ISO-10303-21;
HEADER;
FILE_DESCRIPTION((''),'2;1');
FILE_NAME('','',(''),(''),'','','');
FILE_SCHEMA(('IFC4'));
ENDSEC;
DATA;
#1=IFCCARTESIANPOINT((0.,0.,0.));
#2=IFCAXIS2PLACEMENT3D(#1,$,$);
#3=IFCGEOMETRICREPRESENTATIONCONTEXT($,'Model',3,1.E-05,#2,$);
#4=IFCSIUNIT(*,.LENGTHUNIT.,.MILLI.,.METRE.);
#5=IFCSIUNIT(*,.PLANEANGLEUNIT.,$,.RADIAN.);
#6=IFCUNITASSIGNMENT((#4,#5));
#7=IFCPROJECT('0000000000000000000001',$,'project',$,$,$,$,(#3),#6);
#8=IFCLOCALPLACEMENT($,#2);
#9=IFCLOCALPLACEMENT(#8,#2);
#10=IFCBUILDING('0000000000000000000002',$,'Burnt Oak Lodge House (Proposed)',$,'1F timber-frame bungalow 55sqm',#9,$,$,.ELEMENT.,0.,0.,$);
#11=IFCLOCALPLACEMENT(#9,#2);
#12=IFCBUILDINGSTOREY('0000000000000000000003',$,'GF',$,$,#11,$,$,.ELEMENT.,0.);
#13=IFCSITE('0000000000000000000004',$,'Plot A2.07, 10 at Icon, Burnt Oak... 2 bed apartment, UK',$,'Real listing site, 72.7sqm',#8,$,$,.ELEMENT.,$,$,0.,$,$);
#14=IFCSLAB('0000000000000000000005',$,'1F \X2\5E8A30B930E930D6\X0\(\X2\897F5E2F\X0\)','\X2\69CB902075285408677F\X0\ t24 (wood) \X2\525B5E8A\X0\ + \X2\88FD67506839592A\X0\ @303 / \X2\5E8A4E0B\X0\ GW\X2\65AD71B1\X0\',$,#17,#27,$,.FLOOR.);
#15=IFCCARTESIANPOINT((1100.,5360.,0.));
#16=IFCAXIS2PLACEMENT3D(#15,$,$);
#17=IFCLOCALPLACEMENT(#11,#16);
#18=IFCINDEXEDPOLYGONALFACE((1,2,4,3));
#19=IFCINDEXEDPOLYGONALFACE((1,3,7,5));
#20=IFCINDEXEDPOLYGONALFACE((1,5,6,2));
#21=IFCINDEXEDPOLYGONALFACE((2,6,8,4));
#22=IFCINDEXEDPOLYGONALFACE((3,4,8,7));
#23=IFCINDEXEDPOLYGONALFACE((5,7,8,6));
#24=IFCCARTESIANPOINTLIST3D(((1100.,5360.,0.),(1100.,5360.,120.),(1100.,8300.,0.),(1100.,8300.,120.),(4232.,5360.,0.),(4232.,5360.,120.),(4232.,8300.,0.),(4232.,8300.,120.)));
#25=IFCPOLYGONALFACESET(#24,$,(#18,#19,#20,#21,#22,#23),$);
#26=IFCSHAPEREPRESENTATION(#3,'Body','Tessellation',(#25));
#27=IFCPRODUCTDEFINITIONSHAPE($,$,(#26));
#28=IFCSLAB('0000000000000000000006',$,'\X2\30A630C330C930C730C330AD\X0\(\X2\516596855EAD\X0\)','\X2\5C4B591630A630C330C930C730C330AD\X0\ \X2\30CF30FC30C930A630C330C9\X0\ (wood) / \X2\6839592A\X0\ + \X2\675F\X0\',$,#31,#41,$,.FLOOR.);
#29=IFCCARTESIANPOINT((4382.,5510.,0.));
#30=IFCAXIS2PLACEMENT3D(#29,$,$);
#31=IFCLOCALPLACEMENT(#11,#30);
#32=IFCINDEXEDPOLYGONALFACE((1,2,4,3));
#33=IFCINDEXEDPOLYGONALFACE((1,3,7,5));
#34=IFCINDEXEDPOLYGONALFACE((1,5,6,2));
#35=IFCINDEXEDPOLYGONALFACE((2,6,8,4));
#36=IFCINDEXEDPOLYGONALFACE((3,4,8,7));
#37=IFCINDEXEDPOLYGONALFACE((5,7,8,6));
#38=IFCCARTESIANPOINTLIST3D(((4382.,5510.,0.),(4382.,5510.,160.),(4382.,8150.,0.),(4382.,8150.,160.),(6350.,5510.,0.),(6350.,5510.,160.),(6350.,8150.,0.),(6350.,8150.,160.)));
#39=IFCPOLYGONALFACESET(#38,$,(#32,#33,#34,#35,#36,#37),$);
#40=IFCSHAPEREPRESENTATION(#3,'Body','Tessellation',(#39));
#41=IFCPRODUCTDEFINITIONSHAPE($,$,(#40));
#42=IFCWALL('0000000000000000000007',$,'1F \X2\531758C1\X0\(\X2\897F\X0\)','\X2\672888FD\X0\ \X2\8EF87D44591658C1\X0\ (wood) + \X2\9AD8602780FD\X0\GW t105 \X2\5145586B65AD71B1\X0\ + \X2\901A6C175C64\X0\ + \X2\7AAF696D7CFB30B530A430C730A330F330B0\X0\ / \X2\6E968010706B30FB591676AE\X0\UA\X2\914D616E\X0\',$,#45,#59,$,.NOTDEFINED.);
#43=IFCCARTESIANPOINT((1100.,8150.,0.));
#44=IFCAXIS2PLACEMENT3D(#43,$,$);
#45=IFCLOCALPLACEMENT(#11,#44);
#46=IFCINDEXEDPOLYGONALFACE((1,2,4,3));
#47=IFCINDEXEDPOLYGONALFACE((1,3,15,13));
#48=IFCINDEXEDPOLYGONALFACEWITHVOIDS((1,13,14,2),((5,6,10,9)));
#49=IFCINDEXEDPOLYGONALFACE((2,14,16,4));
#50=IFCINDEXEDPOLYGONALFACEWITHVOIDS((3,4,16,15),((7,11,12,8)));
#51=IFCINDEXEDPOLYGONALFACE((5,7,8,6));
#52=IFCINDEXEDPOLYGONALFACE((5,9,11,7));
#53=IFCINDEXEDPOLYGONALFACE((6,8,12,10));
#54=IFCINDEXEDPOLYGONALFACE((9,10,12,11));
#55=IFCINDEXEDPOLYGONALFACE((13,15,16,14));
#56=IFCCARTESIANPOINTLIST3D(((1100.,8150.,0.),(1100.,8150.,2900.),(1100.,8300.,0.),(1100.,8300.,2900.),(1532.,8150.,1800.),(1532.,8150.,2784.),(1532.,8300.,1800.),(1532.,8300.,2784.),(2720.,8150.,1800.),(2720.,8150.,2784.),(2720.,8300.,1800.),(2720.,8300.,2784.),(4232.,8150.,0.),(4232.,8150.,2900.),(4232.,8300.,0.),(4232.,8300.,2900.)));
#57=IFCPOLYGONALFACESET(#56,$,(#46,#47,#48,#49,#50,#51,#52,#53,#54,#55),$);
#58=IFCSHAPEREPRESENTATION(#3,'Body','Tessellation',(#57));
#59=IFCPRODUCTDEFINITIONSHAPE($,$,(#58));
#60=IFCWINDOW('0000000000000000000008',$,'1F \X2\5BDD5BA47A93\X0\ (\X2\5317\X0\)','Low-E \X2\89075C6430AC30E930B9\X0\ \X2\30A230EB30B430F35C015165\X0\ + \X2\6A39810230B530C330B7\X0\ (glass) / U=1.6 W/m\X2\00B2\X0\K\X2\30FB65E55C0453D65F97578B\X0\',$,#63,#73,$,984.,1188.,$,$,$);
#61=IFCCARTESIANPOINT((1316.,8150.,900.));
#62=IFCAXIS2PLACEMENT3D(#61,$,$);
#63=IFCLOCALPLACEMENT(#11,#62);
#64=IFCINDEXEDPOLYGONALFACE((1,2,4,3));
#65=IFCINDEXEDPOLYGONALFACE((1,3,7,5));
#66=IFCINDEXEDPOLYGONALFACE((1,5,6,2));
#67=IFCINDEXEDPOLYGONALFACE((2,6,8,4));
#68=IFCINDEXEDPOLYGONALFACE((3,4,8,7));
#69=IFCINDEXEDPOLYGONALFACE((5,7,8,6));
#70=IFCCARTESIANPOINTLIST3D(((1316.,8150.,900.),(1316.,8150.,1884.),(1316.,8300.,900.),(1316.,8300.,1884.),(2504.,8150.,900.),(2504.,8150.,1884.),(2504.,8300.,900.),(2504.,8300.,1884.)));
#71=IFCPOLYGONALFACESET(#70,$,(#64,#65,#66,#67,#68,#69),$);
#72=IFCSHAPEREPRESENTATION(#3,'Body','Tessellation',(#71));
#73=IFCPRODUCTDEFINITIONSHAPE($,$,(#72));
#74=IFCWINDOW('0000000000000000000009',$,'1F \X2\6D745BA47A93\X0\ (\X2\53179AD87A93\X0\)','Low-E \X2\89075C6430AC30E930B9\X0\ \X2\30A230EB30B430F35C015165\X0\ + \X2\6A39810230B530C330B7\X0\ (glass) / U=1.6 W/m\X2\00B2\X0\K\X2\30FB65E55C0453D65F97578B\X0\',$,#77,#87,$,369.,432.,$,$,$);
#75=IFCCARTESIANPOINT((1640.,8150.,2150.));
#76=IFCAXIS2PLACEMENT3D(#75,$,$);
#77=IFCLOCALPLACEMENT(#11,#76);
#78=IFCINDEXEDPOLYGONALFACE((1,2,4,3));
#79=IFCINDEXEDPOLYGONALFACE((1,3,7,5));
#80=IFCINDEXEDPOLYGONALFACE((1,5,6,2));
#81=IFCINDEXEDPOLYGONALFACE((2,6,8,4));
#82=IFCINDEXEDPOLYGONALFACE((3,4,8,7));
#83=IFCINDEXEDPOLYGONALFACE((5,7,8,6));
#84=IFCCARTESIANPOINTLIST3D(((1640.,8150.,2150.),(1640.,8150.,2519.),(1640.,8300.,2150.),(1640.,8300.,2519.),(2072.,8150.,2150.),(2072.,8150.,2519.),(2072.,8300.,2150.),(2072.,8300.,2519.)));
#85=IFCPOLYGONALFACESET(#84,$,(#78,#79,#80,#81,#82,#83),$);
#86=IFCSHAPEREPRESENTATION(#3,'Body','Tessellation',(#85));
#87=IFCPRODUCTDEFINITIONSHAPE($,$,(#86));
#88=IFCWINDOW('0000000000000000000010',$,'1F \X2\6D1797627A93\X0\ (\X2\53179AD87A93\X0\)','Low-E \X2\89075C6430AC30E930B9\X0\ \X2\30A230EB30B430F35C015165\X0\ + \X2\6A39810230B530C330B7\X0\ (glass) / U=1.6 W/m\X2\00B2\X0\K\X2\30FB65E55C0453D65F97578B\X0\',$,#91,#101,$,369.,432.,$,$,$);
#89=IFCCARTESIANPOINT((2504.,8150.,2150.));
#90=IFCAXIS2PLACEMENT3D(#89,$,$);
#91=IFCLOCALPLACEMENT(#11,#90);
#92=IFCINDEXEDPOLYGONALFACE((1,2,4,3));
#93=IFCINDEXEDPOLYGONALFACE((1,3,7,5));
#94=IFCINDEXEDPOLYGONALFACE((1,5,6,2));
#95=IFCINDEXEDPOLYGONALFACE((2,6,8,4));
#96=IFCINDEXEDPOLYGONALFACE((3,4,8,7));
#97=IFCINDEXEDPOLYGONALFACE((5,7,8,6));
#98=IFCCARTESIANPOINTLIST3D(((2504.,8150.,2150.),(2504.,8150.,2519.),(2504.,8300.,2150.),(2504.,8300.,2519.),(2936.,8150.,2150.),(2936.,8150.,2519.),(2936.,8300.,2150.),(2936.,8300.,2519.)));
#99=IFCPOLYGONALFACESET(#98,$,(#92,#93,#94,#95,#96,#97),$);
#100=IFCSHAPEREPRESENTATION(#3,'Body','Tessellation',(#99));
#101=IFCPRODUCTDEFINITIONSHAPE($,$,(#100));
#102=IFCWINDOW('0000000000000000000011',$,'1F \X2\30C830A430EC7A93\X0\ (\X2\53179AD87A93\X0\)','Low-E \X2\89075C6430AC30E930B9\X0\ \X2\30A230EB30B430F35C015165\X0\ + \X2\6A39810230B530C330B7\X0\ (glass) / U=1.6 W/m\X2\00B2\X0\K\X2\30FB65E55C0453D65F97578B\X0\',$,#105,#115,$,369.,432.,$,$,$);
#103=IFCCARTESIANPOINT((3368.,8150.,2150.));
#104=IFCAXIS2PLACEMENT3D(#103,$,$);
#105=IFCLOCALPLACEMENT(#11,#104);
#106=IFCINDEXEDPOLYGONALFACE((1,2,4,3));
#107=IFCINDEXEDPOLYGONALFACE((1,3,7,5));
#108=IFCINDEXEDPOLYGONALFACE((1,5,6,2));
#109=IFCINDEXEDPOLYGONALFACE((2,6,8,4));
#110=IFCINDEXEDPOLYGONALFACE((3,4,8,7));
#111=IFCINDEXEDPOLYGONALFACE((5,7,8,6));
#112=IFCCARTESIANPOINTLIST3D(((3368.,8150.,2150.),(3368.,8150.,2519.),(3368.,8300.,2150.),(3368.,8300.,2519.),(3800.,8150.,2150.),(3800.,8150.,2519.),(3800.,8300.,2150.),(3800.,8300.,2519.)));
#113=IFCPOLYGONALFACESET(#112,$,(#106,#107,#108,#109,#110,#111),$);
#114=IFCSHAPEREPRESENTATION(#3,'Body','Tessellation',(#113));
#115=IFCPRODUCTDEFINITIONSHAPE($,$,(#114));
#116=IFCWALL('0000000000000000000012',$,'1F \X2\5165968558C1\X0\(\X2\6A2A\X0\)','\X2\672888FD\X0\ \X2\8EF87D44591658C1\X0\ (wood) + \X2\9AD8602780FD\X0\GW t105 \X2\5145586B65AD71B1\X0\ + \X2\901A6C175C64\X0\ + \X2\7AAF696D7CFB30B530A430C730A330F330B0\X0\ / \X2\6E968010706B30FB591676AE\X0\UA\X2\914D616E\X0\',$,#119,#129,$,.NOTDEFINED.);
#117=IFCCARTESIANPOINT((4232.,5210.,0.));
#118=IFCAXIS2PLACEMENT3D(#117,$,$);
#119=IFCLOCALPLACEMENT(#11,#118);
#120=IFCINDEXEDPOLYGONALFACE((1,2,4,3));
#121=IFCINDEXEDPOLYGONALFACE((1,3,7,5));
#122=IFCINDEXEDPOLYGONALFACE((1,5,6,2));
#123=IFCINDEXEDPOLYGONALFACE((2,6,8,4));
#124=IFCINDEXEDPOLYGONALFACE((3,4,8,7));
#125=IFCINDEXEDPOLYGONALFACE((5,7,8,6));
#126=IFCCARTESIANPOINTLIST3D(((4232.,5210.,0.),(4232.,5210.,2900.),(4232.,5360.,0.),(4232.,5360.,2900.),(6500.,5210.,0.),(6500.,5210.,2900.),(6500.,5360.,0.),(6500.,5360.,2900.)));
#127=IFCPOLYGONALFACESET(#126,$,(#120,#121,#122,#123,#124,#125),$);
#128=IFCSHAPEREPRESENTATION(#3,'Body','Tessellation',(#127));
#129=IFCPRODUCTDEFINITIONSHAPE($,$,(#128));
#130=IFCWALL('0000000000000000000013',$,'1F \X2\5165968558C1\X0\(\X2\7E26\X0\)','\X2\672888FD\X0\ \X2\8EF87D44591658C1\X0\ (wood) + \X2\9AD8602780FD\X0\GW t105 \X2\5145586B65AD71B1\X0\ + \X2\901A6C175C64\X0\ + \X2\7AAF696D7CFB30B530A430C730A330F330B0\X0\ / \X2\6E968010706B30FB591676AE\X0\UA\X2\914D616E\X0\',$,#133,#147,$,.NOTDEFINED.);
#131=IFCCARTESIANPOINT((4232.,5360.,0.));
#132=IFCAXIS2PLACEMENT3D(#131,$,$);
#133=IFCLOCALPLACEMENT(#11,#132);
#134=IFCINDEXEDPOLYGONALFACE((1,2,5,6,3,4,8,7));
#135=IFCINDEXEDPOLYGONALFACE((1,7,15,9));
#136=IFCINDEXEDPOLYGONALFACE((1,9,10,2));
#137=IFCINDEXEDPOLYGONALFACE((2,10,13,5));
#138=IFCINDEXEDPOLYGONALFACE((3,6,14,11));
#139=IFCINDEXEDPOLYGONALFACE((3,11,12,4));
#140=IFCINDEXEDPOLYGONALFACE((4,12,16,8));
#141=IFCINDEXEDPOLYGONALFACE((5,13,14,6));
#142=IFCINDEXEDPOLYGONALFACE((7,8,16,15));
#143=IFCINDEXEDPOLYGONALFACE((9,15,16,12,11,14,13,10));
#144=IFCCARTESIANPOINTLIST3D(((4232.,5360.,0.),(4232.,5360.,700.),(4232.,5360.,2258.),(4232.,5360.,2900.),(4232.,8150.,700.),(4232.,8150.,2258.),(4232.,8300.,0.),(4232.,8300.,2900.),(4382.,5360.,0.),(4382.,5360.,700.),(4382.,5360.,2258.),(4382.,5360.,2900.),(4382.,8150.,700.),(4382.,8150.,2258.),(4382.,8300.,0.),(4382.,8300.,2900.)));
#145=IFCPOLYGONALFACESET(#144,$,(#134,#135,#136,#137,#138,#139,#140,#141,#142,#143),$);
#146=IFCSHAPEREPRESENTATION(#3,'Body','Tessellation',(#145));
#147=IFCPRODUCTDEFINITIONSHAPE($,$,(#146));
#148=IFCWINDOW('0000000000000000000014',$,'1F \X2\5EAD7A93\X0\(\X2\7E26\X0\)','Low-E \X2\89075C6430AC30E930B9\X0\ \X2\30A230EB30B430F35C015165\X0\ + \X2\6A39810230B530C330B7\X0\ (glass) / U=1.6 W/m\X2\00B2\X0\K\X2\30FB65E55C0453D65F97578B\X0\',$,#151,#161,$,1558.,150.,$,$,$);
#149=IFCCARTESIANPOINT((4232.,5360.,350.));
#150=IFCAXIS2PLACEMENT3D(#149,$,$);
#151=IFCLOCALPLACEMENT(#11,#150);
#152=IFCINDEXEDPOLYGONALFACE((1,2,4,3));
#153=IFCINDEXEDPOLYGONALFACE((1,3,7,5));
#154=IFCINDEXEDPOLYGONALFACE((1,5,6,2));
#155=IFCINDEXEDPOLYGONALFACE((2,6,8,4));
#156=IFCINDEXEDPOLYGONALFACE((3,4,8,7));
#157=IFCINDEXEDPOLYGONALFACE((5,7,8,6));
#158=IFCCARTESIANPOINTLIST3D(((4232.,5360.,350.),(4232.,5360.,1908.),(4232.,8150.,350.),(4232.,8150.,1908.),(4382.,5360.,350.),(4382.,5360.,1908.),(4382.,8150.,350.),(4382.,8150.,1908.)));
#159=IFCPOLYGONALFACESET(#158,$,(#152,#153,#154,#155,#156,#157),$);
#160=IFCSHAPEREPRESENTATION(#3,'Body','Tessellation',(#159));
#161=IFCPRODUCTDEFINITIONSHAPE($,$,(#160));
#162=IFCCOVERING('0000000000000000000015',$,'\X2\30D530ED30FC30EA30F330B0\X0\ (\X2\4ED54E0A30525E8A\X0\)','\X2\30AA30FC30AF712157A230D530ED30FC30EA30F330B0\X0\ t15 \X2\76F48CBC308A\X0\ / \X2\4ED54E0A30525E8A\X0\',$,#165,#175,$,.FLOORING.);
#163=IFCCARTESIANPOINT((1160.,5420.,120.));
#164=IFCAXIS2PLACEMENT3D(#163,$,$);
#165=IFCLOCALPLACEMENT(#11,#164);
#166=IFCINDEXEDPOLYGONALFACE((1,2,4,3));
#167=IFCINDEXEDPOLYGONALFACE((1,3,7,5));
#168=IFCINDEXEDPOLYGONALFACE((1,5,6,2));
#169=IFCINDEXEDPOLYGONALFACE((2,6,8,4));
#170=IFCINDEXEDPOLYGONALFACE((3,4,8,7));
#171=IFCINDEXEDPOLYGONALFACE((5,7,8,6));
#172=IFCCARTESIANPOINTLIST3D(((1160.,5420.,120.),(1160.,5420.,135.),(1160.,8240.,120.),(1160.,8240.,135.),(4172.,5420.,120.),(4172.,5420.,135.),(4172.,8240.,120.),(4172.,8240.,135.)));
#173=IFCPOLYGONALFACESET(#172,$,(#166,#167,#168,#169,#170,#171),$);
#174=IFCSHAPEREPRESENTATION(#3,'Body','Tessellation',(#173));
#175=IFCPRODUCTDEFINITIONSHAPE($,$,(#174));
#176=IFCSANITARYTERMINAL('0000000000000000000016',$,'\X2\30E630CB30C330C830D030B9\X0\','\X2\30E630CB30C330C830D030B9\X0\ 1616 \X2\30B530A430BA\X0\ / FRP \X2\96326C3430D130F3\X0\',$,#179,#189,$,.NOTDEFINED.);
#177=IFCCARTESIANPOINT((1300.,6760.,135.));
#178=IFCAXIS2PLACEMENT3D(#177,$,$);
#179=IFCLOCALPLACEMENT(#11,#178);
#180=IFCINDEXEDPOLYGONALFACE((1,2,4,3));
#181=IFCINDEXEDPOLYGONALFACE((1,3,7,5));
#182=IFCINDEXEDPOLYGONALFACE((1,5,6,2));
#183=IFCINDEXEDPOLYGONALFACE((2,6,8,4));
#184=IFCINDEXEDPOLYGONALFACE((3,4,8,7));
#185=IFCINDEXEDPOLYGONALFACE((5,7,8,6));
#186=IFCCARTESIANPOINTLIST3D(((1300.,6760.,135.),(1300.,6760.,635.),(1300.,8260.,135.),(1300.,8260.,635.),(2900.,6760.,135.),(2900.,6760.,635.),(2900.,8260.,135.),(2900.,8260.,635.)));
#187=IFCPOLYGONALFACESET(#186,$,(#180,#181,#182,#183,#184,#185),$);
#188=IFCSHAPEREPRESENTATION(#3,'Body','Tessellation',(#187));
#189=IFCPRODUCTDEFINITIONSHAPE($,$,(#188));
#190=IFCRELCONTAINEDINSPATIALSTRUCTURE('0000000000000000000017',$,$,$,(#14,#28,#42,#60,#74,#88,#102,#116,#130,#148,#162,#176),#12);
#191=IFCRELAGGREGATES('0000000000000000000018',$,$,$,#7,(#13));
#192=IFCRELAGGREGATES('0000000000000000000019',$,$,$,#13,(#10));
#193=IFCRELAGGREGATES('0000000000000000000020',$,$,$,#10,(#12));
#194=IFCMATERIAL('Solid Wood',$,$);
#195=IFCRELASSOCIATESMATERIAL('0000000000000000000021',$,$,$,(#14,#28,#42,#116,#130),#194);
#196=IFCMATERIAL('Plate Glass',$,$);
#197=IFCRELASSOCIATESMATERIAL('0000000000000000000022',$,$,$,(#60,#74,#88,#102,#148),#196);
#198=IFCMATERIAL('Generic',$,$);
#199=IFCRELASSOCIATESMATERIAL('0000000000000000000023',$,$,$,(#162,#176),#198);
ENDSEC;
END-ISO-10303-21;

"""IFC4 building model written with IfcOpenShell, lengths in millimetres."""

from ifc_helpers import new_model, si_unit, frame, frame_2d, origin, place, context, project, spatial, rectangle, extrude, material, element, fill, save


model = new_model("IFC4")

# Units and contexts
model_context = context("Model", 3, precision=1e-05, world=origin())
ifc_project = project(units=[si_unit("LENGTHUNIT", "METRE", prefix="MILLI"), si_unit("PLANEANGLEUNIT", "RADIAN")], contexts=[model_context])

# Site, building, storey
site_placement = place(None, origin())
site = spatial("IfcSite", under=ifc_project, at=site_placement, Name="Plot A2.07, 10 at Icon, Burnt Oak... 2 bed apartment, UK", ObjectType="Real listing site, 72.7sqm", CompositionType="ELEMENT", RefElevation=0.0)
building_placement = place(site_placement, origin())
building = spatial("IfcBuilding", under=site, at=building_placement, Name="Burnt Oak Lodge House (Proposed)", ObjectType="1F timber-frame bungalow 55sqm", CompositionType="ELEMENT", ElevationOfRefHeight=0.0, ElevationOfTerrain=0.0)
storey_placement = place(building_placement, origin())
storey = spatial("IfcBuildingStorey", under=building, at=storey_placement, Name="GF", CompositionType="ELEMENT", Elevation=0.0)

# Slabs
ifc_material_1 = material(Name="Solid Wood")
slab_1_placement = place(storey_placement, frame((1100.0, 5360.0, 0.0)))
element("IfcSlab", 1, at=slab_1_placement, inside=storey, material=ifc_material_1, Name="1F 床スラブ(西帯)", Description="構造用合板 t24 (wood) 剛床 + 製材根太 @303 / 床下 GW断熱", PredefinedType="FLOOR", context=model_context, shape_type="SweptSolid", body=[
    extrude(rectangle(XDim=3132.0, YDim=2940.0, at=frame_2d((1566.0, 1470.0))), frame((1100.0, 5360.0, 0.0)), (0.0, 0.0, 1.0), 120.0),
])
slab_2_placement = place(storey_placement, frame((4382.0, 5510.0, 0.0)))
element("IfcSlab", 2, at=slab_2_placement, inside=storey, material=ifc_material_1, Name="ウッドデッキ(入隅庭)", Description="屋外ウッドデッキ ハードウッド (wood) / 根太 + 束", PredefinedType="FLOOR", context=model_context, shape_type="SweptSolid", body=[
    extrude(rectangle(XDim=1968.0, YDim=2640.0, at=frame_2d((984.0, 1320.0))), frame((4382.0, 5510.0, 0.0)), (0.0, 0.0, 1.0), 160.0),
])

# Wall, openings, windows
wall_1_placement = place(storey_placement, frame((1100.0, 8150.0, 0.0)))
wall_1 = element("IfcWall", 3, at=wall_1_placement, inside=storey, material=ifc_material_1, Name="1F 北壁(西)", Description="木製 軸組外壁 (wood) + 高性能GW t105 充填断熱 + 通気層 + 窯業系サイディング / 準耐火・外皮UA配慮", PredefinedType="NOTDEFINED", context=model_context, shape_type="SweptSolid", body=[
    extrude(rectangle(XDim=3132.0, YDim=150.0, at=frame_2d((1566.0, 75.0))), frame((1100.0, 8150.0, 0.0)), (0.0, 0.0, 1.0), 2900.0),
])
opening_1_placement = place(storey_placement, frame((1316.0, 8150.0, 900.0)))
opening_1 = element("IfcOpeningElement", 4, at=opening_1_placement, cuts=wall_1, PredefinedType="NOTDEFINED", context=model_context, shape_type="SweptSolid", body=[
    extrude(rectangle(XDim=1188.0, YDim=150.0, at=frame_2d((594.0, 75.0))), frame((1316.0, 8150.0, 900.0)), (0.0, 0.0, 1.0), 984.0),
])
opening_2_placement = place(storey_placement, frame((1640.0, 8150.0, 2150.0)))
opening_2 = element("IfcOpeningElement", 5, at=opening_2_placement, cuts=wall_1, PredefinedType="NOTDEFINED", context=model_context, shape_type="SweptSolid", body=[
    extrude(rectangle(XDim=432.0, YDim=150.0, at=frame_2d((216.0, 75.0))), frame((1640.0, 8150.0, 2150.0)), (0.0, 0.0, 1.0), 369.0),
])
opening_3_placement = place(storey_placement, frame((2504.0, 8150.0, 2150.0)))
opening_3 = element("IfcOpeningElement", 6, at=opening_3_placement, cuts=wall_1, PredefinedType="NOTDEFINED", context=model_context, shape_type="SweptSolid", body=[
    extrude(rectangle(XDim=432.0, YDim=150.0, at=frame_2d((216.0, 75.0))), frame((2504.0, 8150.0, 2150.0)), (0.0, 0.0, 1.0), 369.0),
])
opening_4_placement = place(storey_placement, frame((3368.0, 8150.0, 2150.0)))
opening_4 = element("IfcOpeningElement", 7, at=opening_4_placement, cuts=wall_1, PredefinedType="NOTDEFINED", context=model_context, shape_type="SweptSolid", body=[
    extrude(rectangle(XDim=432.0, YDim=150.0, at=frame_2d((216.0, 75.0))), frame((3368.0, 8150.0, 2150.0)), (0.0, 0.0, 1.0), 369.0),
])
ifc_material_2 = material(Name="Plate Glass")
window_1_placement = place(storey_placement, frame((1316.0, 8150.0, 900.0)))
window_1 = element("IfcWindow", 8, at=window_1_placement, inside=storey, material=ifc_material_2, Name="1F 寝室窓 (北)", Description="Low-E 複層ガラス アルゴン封入 + 樹脂サッシ (glass) / U=1.6 W/m²K・日射取得型", OverallHeight=984.0, OverallWidth=1188.0, context=model_context, shape_type="SweptSolid", body=[
    extrude(rectangle(XDim=1188.0, YDim=150.0, at=frame_2d((594.0, 75.0))), frame((1316.0, 8150.0, 900.0)), (0.0, 0.0, 1.0), 984.0),
])
fill(opening_1, window_1)
window_2_placement = place(storey_placement, frame((1640.0, 8150.0, 2150.0)))
window_2 = element("IfcWindow", 9, at=window_2_placement, inside=storey, material=ifc_material_2, Name="1F 浴室窓 (北高窓)", Description="Low-E 複層ガラス アルゴン封入 + 樹脂サッシ (glass) / U=1.6 W/m²K・日射取得型", OverallHeight=369.0, OverallWidth=432.0, context=model_context, shape_type="SweptSolid", body=[
    extrude(rectangle(XDim=432.0, YDim=150.0, at=frame_2d((216.0, 75.0))), frame((1640.0, 8150.0, 2150.0)), (0.0, 0.0, 1.0), 369.0),
])
fill(opening_2, window_2)
window_3_placement = place(storey_placement, frame((2504.0, 8150.0, 2150.0)))
window_3 = element("IfcWindow", 10, at=window_3_placement, inside=storey, material=ifc_material_2, Name="1F 洗面窓 (北高窓)", Description="Low-E 複層ガラス アルゴン封入 + 樹脂サッシ (glass) / U=1.6 W/m²K・日射取得型", OverallHeight=369.0, OverallWidth=432.0, context=model_context, shape_type="SweptSolid", body=[
    extrude(rectangle(XDim=432.0, YDim=150.0, at=frame_2d((216.0, 75.0))), frame((2504.0, 8150.0, 2150.0)), (0.0, 0.0, 1.0), 369.0),
])
fill(opening_3, window_3)
window_4_placement = place(storey_placement, frame((3368.0, 8150.0, 2150.0)))
window_4 = element("IfcWindow", 11, at=window_4_placement, inside=storey, material=ifc_material_2, Name="1F トイレ窓 (北高窓)", Description="Low-E 複層ガラス アルゴン封入 + 樹脂サッシ (glass) / U=1.6 W/m²K・日射取得型", OverallHeight=369.0, OverallWidth=432.0, context=model_context, shape_type="SweptSolid", body=[
    extrude(rectangle(XDim=432.0, YDim=150.0, at=frame_2d((216.0, 75.0))), frame((3368.0, 8150.0, 2150.0)), (0.0, 0.0, 1.0), 369.0),
])
fill(opening_4, window_4)

# Wall
wall_2_placement = place(storey_placement, frame((4232.0, 5210.0, 0.0)))
element("IfcWall", 12, at=wall_2_placement, inside=storey, material=ifc_material_1, Name="1F 入隅壁(横)", Description="木製 軸組外壁 (wood) + 高性能GW t105 充填断熱 + 通気層 + 窯業系サイディング / 準耐火・外皮UA配慮", PredefinedType="NOTDEFINED", context=model_context, shape_type="SweptSolid", body=[
    extrude(rectangle(XDim=2268.0, YDim=150.0, at=frame_2d((1134.0, 75.0))), frame((4232.0, 5210.0, 0.0)), (0.0, 0.0, 1.0), 2900.0),
])

# Wall, opening, window
wall_3_placement = place(storey_placement, frame((4232.0, 5360.0, 0.0)))
wall_3 = element("IfcWall", 13, at=wall_3_placement, inside=storey, material=ifc_material_1, Name="1F 入隅壁(縦)", Description="木製 軸組外壁 (wood) + 高性能GW t105 充填断熱 + 通気層 + 窯業系サイディング / 準耐火・外皮UA配慮", PredefinedType="NOTDEFINED", context=model_context, shape_type="SweptSolid", body=[
    extrude(rectangle(XDim=150.0, YDim=2940.0, at=frame_2d((75.0, 1470.0))), frame((4232.0, 5360.0, 0.0)), (0.0, 0.0, 1.0), 2900.0),
])
opening_5_placement = place(storey_placement, frame((4232.0, 5360.0, 350.0)))
opening_5 = element("IfcOpeningElement", 14, at=opening_5_placement, cuts=wall_3, PredefinedType="NOTDEFINED", context=model_context, shape_type="SweptSolid", body=[
    extrude(rectangle(XDim=150.0, YDim=2790.0, at=frame_2d((75.0, 1395.0))), frame((4232.0, 5360.0, 350.0)), (0.0, 0.0, 1.0), 1558.0),
])
window_5_placement = place(storey_placement, frame((4232.0, 5360.0, 350.0)))
window_5 = element("IfcWindow", 15, at=window_5_placement, inside=storey, material=ifc_material_2, Name="1F 庭窓(縦)", Description="Low-E 複層ガラス アルゴン封入 + 樹脂サッシ (glass) / U=1.6 W/m²K・日射取得型", OverallHeight=1558.0, OverallWidth=150.0, context=model_context, shape_type="SweptSolid", body=[
    extrude(rectangle(XDim=150.0, YDim=2790.0, at=frame_2d((75.0, 1395.0))), frame((4232.0, 5360.0, 350.0)), (0.0, 0.0, 1.0), 1558.0),
])
fill(opening_5, window_5)

# Covering
ifc_material_3 = material(Name="Generic")
covering_placement = place(storey_placement, frame((1160.0, 5420.0, 120.0)))
element("IfcCovering", 16, at=covering_placement, inside=storey, material=ifc_material_3, Name="フローリング (仕上げ床)", Description="オーク無垢フローリング t15 直貼り / 仕上げ床", PredefinedType="FLOORING", context=model_context, shape_type="SweptSolid", body=[
    extrude(rectangle(XDim=3012.0, YDim=2820.0, at=frame_2d((1506.0, 1410.0))), frame((1160.0, 5420.0, 120.0)), (0.0, 0.0, 1.0), 15.0),
])

# Sanitary terminal
sanitary_terminal_1_placement = place(storey_placement, frame((1300.0, 6760.0, 135.0)))
element("IfcSanitaryTerminal", 17, at=sanitary_terminal_1_placement, inside=storey, material=ifc_material_3, Name="ユニットバス", Description="ユニットバス 1616 サイズ / FRP 防水パン", PredefinedType="NOTDEFINED", context=model_context, shape_type="SweptSolid", body=[
    extrude(rectangle(XDim=1600.0, YDim=1500.0, at=frame_2d((800.0, 750.0))), frame((1300.0, 6760.0, 135.0)), (0.0, 0.0, 1.0), 500.0),
])

save(model, "model.ifc")
